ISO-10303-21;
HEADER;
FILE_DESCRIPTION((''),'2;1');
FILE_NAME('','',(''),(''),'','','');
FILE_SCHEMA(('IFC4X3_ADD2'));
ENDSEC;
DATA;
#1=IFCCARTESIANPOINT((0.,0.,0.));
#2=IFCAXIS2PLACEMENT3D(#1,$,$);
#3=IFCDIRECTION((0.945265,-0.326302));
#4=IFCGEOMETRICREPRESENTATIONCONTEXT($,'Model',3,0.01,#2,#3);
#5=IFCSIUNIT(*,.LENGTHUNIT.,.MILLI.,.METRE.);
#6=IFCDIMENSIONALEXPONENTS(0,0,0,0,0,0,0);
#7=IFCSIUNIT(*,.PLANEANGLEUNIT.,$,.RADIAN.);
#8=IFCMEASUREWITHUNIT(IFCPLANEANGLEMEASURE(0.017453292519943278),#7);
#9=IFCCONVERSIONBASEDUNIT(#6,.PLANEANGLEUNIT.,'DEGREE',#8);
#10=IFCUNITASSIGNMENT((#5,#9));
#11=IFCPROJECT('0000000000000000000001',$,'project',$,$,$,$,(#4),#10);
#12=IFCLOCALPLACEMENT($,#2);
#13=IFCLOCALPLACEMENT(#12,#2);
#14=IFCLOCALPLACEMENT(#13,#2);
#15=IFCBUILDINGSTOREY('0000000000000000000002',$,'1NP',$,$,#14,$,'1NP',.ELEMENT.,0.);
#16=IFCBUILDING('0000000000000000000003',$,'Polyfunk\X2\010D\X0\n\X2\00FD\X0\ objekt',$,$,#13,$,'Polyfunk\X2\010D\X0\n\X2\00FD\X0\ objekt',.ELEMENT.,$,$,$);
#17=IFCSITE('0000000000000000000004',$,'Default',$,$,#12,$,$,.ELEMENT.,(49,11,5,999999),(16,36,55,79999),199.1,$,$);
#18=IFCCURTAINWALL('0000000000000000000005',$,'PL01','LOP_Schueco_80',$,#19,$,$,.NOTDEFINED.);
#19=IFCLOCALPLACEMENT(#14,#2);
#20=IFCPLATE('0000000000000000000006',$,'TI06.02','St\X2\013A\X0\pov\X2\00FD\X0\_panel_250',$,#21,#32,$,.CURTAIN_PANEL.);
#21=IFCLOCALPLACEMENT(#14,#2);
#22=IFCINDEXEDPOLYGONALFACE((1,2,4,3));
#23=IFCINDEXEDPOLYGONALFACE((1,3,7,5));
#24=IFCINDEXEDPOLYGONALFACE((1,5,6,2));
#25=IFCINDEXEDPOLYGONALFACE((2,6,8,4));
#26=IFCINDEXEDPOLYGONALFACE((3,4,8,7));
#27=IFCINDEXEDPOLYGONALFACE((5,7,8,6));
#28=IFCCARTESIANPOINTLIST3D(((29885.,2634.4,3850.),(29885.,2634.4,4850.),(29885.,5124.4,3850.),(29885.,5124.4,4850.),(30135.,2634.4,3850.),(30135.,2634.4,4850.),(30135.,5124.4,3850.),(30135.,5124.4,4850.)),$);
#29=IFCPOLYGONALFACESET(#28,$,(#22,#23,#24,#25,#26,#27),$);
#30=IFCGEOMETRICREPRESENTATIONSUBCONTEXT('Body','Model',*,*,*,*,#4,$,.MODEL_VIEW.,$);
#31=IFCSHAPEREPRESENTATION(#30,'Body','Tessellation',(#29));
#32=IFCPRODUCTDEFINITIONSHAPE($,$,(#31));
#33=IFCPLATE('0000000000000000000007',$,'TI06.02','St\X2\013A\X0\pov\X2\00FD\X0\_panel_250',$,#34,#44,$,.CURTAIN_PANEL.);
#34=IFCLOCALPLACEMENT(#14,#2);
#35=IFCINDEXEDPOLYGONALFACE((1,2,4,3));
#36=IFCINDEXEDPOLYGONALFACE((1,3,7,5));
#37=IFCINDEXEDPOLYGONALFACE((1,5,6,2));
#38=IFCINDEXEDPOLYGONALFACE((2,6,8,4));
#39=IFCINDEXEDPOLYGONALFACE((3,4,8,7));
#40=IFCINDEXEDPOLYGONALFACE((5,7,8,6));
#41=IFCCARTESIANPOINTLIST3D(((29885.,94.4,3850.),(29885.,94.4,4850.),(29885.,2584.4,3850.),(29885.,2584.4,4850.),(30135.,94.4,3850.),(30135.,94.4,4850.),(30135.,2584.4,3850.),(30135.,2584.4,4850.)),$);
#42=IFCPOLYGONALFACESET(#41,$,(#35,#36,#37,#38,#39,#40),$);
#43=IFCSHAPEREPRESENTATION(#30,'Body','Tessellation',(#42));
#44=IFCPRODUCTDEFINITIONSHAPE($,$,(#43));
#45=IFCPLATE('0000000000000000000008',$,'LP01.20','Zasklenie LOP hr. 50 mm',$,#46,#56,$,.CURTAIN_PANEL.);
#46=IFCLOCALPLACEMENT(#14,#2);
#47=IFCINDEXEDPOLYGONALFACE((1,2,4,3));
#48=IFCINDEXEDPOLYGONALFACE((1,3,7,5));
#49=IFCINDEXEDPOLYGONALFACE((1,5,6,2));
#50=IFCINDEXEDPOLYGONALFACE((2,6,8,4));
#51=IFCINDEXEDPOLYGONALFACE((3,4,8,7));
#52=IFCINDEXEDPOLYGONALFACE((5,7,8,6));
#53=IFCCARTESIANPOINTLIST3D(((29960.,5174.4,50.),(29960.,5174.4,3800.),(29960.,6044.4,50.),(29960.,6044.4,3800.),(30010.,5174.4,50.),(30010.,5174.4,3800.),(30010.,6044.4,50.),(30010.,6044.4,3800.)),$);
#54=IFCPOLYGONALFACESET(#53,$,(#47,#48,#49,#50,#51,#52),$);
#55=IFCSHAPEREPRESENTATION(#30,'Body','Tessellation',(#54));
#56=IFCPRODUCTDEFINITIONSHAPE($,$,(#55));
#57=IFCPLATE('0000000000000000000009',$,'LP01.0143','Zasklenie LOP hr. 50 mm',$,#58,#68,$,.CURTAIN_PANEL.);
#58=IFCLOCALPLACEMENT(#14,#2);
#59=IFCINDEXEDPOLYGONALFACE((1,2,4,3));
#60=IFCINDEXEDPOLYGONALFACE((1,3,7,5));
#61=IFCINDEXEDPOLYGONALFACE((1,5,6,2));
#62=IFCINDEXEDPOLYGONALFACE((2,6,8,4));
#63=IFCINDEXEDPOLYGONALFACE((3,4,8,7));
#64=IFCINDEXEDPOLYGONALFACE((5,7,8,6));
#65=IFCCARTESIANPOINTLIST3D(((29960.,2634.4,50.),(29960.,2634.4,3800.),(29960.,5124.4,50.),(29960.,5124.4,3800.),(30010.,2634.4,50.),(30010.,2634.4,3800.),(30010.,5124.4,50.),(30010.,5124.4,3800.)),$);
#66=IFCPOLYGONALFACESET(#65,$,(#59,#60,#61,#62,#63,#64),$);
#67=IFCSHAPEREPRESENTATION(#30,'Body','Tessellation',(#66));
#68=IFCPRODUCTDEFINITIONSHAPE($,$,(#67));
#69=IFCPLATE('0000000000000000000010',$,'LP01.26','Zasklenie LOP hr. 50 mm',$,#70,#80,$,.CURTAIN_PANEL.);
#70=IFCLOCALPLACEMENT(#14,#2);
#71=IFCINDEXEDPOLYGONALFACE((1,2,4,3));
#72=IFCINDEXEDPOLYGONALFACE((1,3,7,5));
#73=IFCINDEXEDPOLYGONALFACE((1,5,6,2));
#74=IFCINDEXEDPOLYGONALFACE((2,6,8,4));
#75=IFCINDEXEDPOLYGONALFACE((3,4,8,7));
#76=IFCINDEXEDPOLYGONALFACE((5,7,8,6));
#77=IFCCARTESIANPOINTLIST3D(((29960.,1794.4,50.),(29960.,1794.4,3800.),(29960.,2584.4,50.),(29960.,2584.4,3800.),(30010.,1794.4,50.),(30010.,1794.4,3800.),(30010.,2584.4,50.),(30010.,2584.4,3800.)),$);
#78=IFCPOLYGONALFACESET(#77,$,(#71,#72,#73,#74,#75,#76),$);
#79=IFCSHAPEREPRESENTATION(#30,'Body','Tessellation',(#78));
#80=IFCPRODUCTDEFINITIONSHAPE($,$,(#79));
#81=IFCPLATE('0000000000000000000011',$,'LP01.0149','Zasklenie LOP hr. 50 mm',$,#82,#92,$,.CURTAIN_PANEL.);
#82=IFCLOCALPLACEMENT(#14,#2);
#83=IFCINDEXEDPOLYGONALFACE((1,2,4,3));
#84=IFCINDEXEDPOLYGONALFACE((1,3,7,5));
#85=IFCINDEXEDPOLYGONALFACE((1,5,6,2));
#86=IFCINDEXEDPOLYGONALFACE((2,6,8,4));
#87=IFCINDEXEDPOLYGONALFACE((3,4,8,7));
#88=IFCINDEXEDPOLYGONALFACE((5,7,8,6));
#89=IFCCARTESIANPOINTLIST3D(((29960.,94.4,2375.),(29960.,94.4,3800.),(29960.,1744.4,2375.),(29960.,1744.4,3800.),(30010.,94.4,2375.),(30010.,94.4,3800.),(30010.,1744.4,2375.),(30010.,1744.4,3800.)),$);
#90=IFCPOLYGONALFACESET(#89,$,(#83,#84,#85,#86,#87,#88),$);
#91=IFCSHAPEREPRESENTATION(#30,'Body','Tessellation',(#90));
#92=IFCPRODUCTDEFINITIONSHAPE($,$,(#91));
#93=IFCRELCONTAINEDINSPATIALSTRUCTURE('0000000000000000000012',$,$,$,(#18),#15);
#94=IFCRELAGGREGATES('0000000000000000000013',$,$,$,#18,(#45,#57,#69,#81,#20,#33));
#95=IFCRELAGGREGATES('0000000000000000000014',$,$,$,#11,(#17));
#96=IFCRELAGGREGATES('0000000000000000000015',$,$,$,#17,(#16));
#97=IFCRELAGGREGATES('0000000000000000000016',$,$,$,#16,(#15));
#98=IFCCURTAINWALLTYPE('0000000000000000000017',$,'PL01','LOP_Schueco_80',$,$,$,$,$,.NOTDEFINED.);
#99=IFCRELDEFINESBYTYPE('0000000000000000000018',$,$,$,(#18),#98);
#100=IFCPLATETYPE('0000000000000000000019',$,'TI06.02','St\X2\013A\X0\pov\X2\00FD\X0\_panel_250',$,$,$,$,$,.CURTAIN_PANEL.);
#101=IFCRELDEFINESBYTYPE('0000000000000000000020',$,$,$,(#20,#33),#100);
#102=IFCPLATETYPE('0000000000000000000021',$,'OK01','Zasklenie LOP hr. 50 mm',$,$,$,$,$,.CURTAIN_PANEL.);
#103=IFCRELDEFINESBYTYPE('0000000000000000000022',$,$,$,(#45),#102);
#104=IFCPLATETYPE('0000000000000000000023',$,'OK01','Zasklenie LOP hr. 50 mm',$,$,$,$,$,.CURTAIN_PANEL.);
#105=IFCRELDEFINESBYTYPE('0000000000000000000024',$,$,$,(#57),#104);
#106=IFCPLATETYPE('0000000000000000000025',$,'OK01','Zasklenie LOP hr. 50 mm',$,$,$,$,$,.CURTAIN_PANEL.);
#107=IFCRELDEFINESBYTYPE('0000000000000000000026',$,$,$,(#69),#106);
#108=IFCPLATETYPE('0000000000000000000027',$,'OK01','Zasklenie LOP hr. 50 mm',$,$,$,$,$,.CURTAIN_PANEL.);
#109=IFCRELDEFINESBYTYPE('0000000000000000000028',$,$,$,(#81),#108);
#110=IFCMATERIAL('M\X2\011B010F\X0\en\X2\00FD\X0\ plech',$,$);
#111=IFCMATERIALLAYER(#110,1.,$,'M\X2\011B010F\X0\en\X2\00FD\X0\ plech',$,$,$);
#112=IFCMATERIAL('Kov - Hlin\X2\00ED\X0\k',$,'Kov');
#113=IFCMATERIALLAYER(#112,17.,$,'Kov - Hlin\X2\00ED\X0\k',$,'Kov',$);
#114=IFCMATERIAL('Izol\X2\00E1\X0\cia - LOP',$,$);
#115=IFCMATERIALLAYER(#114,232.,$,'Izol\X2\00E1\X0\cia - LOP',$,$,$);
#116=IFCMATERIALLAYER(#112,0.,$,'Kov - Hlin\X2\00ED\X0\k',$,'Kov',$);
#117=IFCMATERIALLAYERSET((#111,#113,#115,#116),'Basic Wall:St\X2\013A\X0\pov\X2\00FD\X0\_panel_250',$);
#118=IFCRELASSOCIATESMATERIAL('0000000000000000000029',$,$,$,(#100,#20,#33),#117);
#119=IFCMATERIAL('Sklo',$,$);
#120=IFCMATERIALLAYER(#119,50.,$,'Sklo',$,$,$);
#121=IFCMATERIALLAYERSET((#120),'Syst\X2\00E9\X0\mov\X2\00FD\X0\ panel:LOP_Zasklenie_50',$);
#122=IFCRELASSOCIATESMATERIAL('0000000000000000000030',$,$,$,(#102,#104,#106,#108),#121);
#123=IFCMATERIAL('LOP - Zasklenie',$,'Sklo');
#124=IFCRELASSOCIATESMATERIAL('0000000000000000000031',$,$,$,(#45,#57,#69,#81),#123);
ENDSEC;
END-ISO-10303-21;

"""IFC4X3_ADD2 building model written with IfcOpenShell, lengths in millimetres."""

from ifc_helpers import new_model, entity, si_unit, converted_unit, direction, frame, frame_2d, origin, origin_2d_with_axis, place, context, subcontext, project, spatial, rectangle, extrude, source, transform, mapped, material, layer, layer_set, layer_usage, type_object, type_shapes, element, aggregate, save


model = new_model("IFC4X3_ADD2")

# Units and contexts
model_context = context("Model", 3, precision=0.01, world=origin(), true_north=direction((0.945265, -0.326302)))
body_context = subcontext(model_context, "Body", "Model", "MODEL_VIEW")
ifc_project = project(units=[si_unit("LENGTHUNIT", "METRE", prefix="MILLI"), converted_unit("PLANEANGLEUNIT", "DEGREE", entity("IfcPlaneAngleMeasure", 0.017453292519943278), si_unit("PLANEANGLEUNIT", "RADIAN"), dimensions=[0, 0, 0, 0, 0, 0, 0])], contexts=[model_context])

# Site, building, storey
site_placement = place(None, origin())
site = spatial("IfcSite", under=ifc_project, at=site_placement, Name="Default", CompositionType="ELEMENT", RefLatitude=(49, 11, 5, 999999), RefLongitude=(16, 36, 55, 79999), RefElevation=199.1)
building_placement = place(site_placement, origin())
building = spatial("IfcBuilding", under=site, at=building_placement, Name="Polyfunkčný objekt", LongName="Polyfunkčný objekt", CompositionType="ELEMENT")
storey_placement = place(building_placement, origin())
storey = spatial("IfcBuildingStorey", under=building, at=storey_placement, Name="1NP", LongName="1NP", CompositionType="ELEMENT", Elevation=0.0)

# Curtain wall, plates
curtain_wall_type = type_object("IfcCurtainWallType", Name="PL01", Description="LOP_Schueco_80", PredefinedType="NOTDEFINED")
curtain_wall_placement = place(storey_placement, origin())
curtain_wall = element("IfcCurtainWall", 1, at=curtain_wall_placement, inside=storey, type_object=curtain_wall_type, Name="PL01", Description="LOP_Schueco_80", PredefinedType="NOTDEFINED")
ifc_material_1 = material(Name="Měďený plech")
ifc_layer_1 = layer(ifc_material_1, 1.0, Name="Měďený plech")
ifc_material_2 = material(Name="Kov - Hliník", Category="Kov")
ifc_layer_2 = layer(ifc_material_2, 17.0, Name="Kov - Hliník", Category="Kov")
ifc_material_3 = material(Name="Izolácia - LOP")
ifc_layer_3 = layer(ifc_material_3, 232.0, Name="Izolácia - LOP")
ifc_layer_4 = layer(ifc_material_2, 0.0, Name="Kov - Hliník", Category="Kov")
ifc_layer_set_1 = layer_set([ifc_layer_1, ifc_layer_2, ifc_layer_3, ifc_layer_4], Name="Basic Wall:Stĺpový_panel_250")
ifc_layer_usage_1 = layer_usage(ifc_layer_set_1, "AXIS2", "POSITIVE", -125.0)
plate_type_1 = type_object("IfcPlateType", Name="TI06.02", Description="Stĺpový_panel_250", PredefinedType="CURTAIN_PANEL", material=ifc_layer_set_1)
plate_1_placement = place(storey_placement, frame((30010.0, 5124.4, 3850.0), z_axis=(0.0, 0.0, 1.0), x_axis=(0.0, -1.0, 0.0)))
plate_1 = element("IfcPlate", 2, at=plate_1_placement, type_object=plate_type_1, material=ifc_layer_usage_1, Name="TI06.02", Description="Stĺpový_panel_250", PredefinedType="CURTAIN_PANEL", context=body_context, shape_type="SweptSolid", body=[
    extrude(rectangle(XDim=250.0, YDim=2490.0, at=frame_2d((0.0, 0.0), x_axis=(1.0, 0.0))), frame((1245.0, 0.0, 0.0), z_axis=(0.0, 0.0, 1.0), x_axis=(0.0, 1.0, 0.0)), (0.0, 0.0, 1.0), 1000.0),
])
ifc_layer_usage_2 = layer_usage(ifc_layer_set_1, "AXIS2", "POSITIVE", -125.0)
plate_2_placement = place(storey_placement, frame((30010.0, 2584.4, 3850.0), z_axis=(0.0, 0.0, 1.0), x_axis=(0.0, -1.0, 0.0)))
plate_2 = element("IfcPlate", 3, at=plate_2_placement, type_object=plate_type_1, material=ifc_layer_usage_2, Name="TI06.02", Description="Stĺpový_panel_250", PredefinedType="CURTAIN_PANEL", context=body_context, shape_type="SweptSolid", body=[
    extrude(rectangle(XDim=250.0, YDim=2490.0, at=frame_2d((0.0, 0.0), x_axis=(1.0, 0.0))), frame((1245.0, 0.0, 0.0), z_axis=(0.0, 0.0, 1.0), x_axis=(0.0, 1.0, 0.0)), (0.0, 0.0, 1.0), 1000.0),
])
ifc_material_4 = material(Name="LOP - Zasklenie", Category="Sklo")
ifc_material_5 = material(Name="Sklo")
ifc_layer_5 = layer(ifc_material_5, 50.0, Name="Sklo")
ifc_layer_set_2 = layer_set([ifc_layer_5], Name="Systémový panel:LOP_Zasklenie_50")
plate_type_2 = type_object("IfcPlateType", Name="OK01", Description="Zasklenie LOP hr. 50 mm", PredefinedType="CURTAIN_PANEL", material=ifc_layer_set_2)
shared_shape_1 = source(origin(), body_context, "Body", "SweptSolid", [
    extrude(rectangle(XDim=3750.0, YDim=870.0, at=frame_2d((-141.7, 0.0), x_axis=(1.0, 0.0))), frame((0.0, -50.0, 2016.7), z_axis=(0.0, 1.0, 0.0), x_axis=(0.0, 0.0, 1.0)), (0.0, 0.0, 1.0), 50.0),
])
type_shapes(plate_type_2, [shared_shape_1])
plate_3_placement = place(curtain_wall_placement, frame((30010.0, 5609.4, 50.0), z_axis=(0.0, 0.0, 1.0), x_axis=(0.0, -1.0, 0.0)))
plate_3 = element("IfcPlate", 4, at=plate_3_placement, type_object=plate_type_2, material=ifc_material_4, Name="LP01.20", Description="Zasklenie LOP hr. 50 mm", PredefinedType="CURTAIN_PANEL", context=body_context, shape_type="MappedRepresentation", body=[
    mapped(shared_shape_1, transform((0.0, 0.0, 0.0), scale=1.0)),
])
plate_type_3 = type_object("IfcPlateType", Name="OK01", Description="Zasklenie LOP hr. 50 mm", PredefinedType="CURTAIN_PANEL", material=ifc_layer_set_2)
shared_shape_2 = source(origin(), body_context, "Body", "SweptSolid", [
    extrude(rectangle(XDim=3750.0, YDim=2490.0, at=frame_2d((-141.7, 0.0), x_axis=(1.0, 0.0))), frame((0.0, -50.0, 2016.7), z_axis=(0.0, 1.0, 0.0), x_axis=(0.0, 0.0, 1.0)), (0.0, 0.0, 1.0), 50.0),
])
type_shapes(plate_type_3, [shared_shape_2])
plate_4_placement = place(curtain_wall_placement, frame((30010.0, 3879.4, 50.0), z_axis=(0.0, 0.0, 1.0), x_axis=(0.0, -1.0, 0.0)))
plate_4 = element("IfcPlate", 5, at=plate_4_placement, type_object=plate_type_3, material=ifc_material_4, Name="LP01.0143", Description="Zasklenie LOP hr. 50 mm", PredefinedType="CURTAIN_PANEL", context=body_context, shape_type="MappedRepresentation", body=[
    mapped(shared_shape_2, transform((0.0, 0.0, 0.0), scale=1.0)),
])
plate_type_4 = type_object("IfcPlateType", Name="OK01", Description="Zasklenie LOP hr. 50 mm", PredefinedType="CURTAIN_PANEL", material=ifc_layer_set_2)
shared_shape_3 = source(origin(), body_context, "Body", "SweptSolid", [
    extrude(rectangle(XDim=3750.0, YDim=790.0, at=frame_2d((-141.7, 0.0), x_axis=(1.0, 0.0))), frame((0.0, -50.0, 2016.7), z_axis=(0.0, 1.0, 0.0), x_axis=(0.0, 0.0, 1.0)), (0.0, 0.0, 1.0), 50.0),
])
type_shapes(plate_type_4, [shared_shape_3])
plate_5_placement = place(curtain_wall_placement, frame((30010.0, 2189.4, 50.0), z_axis=(0.0, 0.0, 1.0), x_axis=(0.0, -1.0, 0.0)))
plate_5 = element("IfcPlate", 6, at=plate_5_placement, type_object=plate_type_4, material=ifc_material_4, Name="LP01.26", Description="Zasklenie LOP hr. 50 mm", PredefinedType="CURTAIN_PANEL", context=body_context, shape_type="MappedRepresentation", body=[
    mapped(shared_shape_3, transform((0.0, 0.0, 0.0), scale=1.0)),
])
plate_type_5 = type_object("IfcPlateType", Name="OK01", Description="Zasklenie LOP hr. 50 mm", PredefinedType="CURTAIN_PANEL", material=ifc_layer_set_2)
shared_shape_4 = source(origin(), body_context, "Body", "SweptSolid", [
    extrude(rectangle(XDim=50.0, YDim=1650.0, at=origin_2d_with_axis()), frame((0.0, -25.0, 0.0), z_axis=(0.0, 0.0, 1.0), x_axis=(0.0, 1.0, 0.0)), (0.0, 0.0, 1.0), 1425.0),
])
type_shapes(plate_type_5, [shared_shape_4])
plate_6_placement = place(curtain_wall_placement, frame((30010.0, 919.4, 2375.0), z_axis=(0.0, 0.0, 1.0), x_axis=(0.0, -1.0, 0.0)))
plate_6 = element("IfcPlate", 7, at=plate_6_placement, type_object=plate_type_5, material=ifc_material_4, Name="LP01.0149", Description="Zasklenie LOP hr. 50 mm", PredefinedType="CURTAIN_PANEL", context=body_context, shape_type="MappedRepresentation", body=[
    mapped(shared_shape_4, transform((0.0, 0.0, 0.0), scale=1.0)),
])
aggregate(curtain_wall, [plate_3, plate_4, plate_5, plate_6, plate_1, plate_2])

save(model, "model.ifc")
